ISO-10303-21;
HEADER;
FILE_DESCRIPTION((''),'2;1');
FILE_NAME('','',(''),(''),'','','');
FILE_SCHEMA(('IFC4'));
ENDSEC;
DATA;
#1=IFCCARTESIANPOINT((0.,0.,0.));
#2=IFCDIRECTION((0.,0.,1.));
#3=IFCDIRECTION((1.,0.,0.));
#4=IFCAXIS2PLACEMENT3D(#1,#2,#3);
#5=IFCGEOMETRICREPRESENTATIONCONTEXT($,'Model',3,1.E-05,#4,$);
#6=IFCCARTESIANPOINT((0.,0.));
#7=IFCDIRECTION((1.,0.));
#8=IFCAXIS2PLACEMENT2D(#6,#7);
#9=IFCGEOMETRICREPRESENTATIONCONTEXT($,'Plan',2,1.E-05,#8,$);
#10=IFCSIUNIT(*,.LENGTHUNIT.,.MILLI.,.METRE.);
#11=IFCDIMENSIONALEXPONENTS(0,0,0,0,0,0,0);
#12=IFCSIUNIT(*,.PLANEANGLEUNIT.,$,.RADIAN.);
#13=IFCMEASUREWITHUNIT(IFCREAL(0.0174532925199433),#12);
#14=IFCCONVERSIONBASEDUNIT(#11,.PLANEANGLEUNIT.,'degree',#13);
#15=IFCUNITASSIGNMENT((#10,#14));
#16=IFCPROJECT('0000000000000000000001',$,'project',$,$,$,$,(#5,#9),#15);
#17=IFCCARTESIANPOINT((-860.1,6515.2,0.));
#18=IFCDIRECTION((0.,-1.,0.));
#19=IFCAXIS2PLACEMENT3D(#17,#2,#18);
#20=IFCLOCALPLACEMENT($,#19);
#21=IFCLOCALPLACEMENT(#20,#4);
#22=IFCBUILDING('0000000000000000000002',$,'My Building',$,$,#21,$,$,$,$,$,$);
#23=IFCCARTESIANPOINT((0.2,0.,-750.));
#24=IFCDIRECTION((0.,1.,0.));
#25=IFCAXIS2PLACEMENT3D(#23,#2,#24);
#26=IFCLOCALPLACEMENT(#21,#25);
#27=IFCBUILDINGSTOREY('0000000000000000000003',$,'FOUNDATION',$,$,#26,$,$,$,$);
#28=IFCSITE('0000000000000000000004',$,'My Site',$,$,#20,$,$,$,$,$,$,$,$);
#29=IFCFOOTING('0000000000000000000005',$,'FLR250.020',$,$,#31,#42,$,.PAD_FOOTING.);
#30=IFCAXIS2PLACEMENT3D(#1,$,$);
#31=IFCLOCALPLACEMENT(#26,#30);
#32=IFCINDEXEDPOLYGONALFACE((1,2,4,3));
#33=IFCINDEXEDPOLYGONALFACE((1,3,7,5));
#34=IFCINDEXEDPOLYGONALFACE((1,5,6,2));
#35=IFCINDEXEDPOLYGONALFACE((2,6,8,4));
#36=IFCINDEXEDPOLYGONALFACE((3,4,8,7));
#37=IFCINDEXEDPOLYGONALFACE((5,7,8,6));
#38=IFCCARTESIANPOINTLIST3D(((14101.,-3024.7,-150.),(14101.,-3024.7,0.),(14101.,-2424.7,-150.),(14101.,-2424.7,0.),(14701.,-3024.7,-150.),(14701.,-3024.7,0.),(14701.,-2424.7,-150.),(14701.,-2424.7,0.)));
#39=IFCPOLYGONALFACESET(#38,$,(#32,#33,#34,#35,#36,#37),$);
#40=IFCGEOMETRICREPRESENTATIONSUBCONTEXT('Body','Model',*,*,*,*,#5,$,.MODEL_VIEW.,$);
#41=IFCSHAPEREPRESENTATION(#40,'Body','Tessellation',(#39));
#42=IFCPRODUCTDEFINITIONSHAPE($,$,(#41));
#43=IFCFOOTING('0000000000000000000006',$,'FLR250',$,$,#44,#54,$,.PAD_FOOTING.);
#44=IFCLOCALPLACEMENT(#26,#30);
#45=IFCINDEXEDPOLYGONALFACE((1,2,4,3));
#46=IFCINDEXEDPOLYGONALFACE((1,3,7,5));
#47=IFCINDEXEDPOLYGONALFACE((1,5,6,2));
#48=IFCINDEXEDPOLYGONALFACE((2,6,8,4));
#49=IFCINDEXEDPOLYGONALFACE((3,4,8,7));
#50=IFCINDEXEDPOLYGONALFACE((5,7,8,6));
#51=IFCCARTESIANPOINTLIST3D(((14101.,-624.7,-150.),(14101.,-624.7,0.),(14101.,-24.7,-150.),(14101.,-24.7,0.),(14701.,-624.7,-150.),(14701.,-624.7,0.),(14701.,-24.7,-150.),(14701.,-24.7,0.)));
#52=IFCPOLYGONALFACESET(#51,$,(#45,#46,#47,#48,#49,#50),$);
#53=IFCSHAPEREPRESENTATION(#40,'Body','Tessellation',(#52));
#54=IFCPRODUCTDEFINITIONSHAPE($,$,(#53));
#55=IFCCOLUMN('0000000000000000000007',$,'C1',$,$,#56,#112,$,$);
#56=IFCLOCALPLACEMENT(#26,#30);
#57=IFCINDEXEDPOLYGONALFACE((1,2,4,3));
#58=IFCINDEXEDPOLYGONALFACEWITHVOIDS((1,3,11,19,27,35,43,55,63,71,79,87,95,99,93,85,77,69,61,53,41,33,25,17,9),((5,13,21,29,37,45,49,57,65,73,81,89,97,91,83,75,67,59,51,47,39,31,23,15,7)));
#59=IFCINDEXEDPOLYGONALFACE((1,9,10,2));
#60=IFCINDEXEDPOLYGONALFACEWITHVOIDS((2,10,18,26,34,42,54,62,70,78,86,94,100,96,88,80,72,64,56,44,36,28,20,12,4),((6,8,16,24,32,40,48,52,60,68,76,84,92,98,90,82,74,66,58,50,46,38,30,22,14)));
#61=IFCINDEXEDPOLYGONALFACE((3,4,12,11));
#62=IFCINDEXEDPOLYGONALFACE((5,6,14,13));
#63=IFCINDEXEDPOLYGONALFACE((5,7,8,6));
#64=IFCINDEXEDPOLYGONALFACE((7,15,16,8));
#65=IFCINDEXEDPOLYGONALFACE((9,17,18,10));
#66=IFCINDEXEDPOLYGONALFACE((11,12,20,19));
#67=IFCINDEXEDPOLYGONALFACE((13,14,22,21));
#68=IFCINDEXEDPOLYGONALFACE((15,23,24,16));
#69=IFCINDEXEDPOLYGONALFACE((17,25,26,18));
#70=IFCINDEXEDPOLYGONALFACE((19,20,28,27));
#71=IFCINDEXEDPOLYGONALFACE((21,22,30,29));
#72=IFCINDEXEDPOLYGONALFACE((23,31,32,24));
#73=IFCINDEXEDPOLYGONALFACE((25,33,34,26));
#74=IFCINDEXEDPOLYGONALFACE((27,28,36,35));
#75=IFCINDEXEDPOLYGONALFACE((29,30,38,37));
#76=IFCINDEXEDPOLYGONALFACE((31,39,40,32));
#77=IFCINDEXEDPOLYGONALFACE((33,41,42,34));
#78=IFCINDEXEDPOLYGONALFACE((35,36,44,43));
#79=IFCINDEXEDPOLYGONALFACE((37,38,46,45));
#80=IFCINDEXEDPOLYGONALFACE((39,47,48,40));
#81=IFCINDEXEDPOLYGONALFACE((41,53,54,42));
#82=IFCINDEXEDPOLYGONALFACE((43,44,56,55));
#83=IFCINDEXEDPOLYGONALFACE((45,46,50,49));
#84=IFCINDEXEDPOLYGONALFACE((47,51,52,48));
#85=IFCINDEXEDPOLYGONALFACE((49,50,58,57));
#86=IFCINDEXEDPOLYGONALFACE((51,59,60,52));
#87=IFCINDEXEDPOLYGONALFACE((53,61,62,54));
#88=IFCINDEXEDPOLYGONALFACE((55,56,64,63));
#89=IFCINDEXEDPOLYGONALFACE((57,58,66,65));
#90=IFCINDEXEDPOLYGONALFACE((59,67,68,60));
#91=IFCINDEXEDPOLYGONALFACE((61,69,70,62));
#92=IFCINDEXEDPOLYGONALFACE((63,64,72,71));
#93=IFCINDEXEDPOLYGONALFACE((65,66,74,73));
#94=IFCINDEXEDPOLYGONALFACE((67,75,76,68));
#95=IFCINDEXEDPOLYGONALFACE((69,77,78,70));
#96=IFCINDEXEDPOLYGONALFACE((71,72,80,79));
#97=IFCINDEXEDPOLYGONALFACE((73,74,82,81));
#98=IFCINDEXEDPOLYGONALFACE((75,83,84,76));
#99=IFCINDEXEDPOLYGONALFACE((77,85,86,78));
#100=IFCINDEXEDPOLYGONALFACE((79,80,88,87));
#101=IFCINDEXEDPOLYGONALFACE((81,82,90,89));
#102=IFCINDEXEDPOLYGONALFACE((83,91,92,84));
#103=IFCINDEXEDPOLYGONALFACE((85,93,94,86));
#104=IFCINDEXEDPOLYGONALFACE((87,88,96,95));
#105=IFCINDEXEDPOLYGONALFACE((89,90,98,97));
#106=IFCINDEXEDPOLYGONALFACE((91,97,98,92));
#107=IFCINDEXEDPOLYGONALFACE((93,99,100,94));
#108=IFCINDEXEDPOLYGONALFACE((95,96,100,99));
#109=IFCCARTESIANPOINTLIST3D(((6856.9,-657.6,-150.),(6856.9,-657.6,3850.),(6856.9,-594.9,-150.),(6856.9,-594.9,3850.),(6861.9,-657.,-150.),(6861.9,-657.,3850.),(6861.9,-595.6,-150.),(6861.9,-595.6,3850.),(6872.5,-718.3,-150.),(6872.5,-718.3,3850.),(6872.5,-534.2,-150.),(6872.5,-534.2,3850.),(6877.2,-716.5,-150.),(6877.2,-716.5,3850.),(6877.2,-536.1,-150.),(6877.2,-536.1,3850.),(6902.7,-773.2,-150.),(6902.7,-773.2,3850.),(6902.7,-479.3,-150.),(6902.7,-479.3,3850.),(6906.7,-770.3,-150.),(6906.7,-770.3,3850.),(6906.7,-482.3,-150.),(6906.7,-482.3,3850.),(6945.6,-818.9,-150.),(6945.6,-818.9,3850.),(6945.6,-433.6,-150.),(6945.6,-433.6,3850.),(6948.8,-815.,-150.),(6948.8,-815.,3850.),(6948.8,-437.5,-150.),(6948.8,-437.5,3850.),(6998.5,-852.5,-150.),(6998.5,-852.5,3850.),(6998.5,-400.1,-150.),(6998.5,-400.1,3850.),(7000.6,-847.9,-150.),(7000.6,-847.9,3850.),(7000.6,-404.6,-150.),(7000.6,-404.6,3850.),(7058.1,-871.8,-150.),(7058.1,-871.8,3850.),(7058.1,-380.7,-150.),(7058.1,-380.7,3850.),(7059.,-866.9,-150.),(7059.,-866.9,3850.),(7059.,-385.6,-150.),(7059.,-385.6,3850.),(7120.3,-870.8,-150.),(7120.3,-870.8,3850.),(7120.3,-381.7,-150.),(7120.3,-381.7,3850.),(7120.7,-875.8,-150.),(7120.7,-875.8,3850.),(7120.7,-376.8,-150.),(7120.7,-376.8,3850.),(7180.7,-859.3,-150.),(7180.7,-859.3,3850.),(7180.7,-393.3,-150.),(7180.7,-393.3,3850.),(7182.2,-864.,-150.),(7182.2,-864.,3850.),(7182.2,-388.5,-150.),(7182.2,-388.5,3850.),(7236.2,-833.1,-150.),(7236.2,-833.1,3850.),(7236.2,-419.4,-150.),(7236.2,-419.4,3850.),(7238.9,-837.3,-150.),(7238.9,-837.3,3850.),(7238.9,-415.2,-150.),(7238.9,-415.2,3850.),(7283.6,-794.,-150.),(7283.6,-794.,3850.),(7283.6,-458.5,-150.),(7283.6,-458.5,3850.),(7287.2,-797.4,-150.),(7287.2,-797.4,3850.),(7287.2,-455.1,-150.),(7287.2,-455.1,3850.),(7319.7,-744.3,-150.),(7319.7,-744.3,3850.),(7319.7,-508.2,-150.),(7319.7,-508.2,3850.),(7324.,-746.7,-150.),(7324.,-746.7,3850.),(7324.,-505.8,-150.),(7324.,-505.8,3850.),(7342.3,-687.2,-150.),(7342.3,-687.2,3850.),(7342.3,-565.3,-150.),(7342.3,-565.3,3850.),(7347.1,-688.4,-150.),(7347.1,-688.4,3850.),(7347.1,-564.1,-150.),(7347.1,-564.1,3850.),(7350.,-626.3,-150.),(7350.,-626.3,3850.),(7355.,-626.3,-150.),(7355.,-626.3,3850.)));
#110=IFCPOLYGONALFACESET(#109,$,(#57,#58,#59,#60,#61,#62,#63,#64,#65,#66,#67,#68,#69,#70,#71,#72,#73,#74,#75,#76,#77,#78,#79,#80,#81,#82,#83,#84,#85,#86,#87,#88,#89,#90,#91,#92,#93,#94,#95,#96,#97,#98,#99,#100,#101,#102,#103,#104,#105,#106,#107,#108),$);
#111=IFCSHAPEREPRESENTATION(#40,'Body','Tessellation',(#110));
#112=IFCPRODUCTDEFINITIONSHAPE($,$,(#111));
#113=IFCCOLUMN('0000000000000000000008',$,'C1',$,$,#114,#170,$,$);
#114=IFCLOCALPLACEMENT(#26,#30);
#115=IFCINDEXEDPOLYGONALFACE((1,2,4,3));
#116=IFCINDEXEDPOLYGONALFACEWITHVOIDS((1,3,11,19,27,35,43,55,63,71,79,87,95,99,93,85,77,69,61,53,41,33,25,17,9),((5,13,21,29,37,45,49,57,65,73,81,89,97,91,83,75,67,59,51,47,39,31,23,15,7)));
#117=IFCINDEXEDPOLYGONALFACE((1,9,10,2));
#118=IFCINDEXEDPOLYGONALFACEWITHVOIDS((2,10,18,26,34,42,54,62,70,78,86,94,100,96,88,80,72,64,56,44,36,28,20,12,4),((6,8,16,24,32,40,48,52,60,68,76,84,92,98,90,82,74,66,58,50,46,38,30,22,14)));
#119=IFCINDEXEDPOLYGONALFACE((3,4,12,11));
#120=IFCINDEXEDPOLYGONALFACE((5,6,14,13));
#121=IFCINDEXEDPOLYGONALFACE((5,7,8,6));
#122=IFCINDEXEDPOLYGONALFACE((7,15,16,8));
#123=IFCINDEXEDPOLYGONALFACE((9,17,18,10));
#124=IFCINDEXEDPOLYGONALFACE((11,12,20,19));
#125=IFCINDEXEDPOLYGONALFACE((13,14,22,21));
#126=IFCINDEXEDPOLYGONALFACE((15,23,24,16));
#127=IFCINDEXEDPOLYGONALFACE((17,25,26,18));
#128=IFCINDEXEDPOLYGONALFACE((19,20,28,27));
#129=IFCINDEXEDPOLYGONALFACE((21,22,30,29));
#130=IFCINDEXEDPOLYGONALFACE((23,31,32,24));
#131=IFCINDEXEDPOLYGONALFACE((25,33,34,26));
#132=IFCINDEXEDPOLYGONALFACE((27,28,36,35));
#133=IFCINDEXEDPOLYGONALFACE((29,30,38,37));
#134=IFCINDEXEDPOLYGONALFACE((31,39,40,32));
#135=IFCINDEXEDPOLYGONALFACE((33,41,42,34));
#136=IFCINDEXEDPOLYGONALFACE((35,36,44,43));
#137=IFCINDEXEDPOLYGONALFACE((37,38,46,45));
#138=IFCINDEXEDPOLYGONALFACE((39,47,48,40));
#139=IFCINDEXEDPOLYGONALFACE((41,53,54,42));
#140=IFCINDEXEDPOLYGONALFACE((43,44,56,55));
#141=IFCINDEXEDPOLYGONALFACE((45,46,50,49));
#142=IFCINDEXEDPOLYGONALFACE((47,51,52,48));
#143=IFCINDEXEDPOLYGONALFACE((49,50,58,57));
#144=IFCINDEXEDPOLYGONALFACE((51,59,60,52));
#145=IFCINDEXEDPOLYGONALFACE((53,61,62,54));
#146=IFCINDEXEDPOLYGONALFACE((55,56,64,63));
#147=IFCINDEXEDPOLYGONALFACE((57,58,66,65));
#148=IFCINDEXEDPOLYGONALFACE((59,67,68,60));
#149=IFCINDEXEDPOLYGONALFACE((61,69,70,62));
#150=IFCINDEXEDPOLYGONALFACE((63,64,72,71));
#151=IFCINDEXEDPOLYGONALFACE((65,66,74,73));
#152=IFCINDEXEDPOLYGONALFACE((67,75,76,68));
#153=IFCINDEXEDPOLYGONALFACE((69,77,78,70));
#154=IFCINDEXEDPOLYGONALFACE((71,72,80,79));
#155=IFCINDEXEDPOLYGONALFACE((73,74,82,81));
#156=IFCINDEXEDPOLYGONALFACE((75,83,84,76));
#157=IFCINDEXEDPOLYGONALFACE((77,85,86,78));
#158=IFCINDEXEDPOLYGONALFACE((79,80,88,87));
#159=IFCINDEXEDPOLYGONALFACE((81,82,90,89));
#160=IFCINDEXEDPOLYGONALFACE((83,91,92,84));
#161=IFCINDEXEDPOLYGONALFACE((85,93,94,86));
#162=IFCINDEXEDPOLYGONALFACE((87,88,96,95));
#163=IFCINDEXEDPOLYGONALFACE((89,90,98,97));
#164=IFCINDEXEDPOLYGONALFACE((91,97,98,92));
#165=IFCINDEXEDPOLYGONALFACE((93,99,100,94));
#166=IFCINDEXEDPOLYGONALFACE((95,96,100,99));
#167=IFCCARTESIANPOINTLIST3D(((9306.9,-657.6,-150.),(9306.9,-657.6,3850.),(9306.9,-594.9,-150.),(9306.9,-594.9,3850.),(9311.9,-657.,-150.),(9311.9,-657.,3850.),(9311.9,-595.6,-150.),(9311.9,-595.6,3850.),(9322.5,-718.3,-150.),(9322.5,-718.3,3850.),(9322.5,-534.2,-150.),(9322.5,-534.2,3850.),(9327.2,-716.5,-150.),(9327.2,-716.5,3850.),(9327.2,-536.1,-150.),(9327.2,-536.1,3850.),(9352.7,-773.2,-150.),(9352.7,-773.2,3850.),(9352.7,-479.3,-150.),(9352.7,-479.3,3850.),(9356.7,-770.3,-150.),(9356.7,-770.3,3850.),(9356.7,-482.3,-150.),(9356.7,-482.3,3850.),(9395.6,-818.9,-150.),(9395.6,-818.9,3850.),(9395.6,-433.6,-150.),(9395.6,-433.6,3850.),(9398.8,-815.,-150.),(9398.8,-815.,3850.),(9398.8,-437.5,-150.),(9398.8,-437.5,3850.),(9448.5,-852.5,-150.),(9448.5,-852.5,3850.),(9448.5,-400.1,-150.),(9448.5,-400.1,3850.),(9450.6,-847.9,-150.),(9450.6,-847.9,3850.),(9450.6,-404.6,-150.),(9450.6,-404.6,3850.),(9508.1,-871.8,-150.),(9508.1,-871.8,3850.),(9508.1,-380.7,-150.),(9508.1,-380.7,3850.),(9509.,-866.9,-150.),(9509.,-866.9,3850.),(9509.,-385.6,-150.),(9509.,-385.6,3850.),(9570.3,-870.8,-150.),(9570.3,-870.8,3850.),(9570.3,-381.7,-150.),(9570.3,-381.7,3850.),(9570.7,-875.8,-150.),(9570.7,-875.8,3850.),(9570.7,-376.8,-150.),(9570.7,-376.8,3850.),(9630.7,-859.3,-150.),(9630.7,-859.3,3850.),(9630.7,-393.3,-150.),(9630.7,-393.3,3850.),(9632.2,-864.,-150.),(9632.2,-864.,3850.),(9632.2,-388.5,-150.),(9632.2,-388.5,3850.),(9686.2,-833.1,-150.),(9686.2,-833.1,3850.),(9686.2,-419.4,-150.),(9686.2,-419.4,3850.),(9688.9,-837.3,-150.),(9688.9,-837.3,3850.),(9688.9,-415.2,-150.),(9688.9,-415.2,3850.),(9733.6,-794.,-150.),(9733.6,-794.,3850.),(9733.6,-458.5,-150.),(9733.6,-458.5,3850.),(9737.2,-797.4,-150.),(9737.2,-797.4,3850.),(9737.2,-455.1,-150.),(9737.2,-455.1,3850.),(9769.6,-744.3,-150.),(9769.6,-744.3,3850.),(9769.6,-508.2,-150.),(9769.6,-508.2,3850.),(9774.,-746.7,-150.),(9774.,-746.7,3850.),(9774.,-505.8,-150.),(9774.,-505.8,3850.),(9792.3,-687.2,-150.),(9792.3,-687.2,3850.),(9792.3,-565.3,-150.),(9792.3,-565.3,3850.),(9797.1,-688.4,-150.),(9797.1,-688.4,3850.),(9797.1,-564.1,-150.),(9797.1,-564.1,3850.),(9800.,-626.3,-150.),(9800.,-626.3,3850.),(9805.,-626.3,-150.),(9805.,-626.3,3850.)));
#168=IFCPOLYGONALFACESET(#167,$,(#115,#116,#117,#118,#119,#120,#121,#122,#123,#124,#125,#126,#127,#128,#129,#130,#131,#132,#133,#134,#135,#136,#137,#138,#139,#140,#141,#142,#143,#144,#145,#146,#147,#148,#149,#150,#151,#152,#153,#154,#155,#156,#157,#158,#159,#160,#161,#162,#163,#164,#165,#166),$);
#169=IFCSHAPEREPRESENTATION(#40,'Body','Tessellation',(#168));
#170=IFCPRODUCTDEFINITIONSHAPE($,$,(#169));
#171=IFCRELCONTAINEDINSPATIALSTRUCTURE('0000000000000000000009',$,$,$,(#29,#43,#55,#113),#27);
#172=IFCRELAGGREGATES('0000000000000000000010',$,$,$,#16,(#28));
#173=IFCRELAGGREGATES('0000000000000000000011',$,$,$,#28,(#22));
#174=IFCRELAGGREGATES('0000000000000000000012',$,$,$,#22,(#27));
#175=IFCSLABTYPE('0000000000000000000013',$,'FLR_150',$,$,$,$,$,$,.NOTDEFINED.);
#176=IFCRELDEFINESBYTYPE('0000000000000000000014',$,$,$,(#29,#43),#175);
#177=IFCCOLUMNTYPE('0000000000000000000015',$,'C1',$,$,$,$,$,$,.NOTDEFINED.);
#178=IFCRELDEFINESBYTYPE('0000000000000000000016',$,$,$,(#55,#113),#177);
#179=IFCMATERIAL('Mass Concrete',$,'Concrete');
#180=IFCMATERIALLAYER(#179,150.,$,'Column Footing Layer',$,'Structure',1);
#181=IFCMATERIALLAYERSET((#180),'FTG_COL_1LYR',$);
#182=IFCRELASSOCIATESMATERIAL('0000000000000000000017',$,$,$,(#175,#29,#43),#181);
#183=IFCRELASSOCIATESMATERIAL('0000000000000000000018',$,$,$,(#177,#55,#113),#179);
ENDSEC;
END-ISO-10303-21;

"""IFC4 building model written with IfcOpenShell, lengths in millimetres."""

from ifc_helpers import new_model, entity, si_unit, converted_unit, frame, origin_with_axes, origin_2d_with_axis, place, context, subcontext, project, spatial, line, indexed_curve, rectangle, hollow_circle, outline, extrude, material, layer, layer_set, layer_usage, material_profile, profile_set, profile_usage, type_object, element, save


model = new_model("IFC4")

# Units and contexts
model_context = context("Model", 3, precision=1e-05, world=origin_with_axes())
plan_context = context("Plan", 2, precision=1e-05, world=origin_2d_with_axis())
body_context = subcontext(model_context, "Body", "Model", "MODEL_VIEW")
ifc_project = project(units=[si_unit("LENGTHUNIT", "METRE", prefix="MILLI"), converted_unit("PLANEANGLEUNIT", "degree", entity("IfcReal", 0.0174532925199433), si_unit("PLANEANGLEUNIT", "RADIAN"), dimensions=[0, 0, 0, 0, 0, 0, 0])], contexts=[model_context, plan_context])

# Site, building, storey
site_placement = place(None, frame((-860.1, 6515.2, 0.0), z_axis=(0.0, 0.0, 1.0), x_axis=(0.0, -1.0, 0.0)))
site = spatial("IfcSite", under=ifc_project, at=site_placement, Name="My Site")
building_placement = place(site_placement, frame((0.0, 0.0, 0.0), z_axis=(0.0, 0.0, 1.0), x_axis=(1.0, 0.0, 0.0)))
building = spatial("IfcBuilding", under=site, at=building_placement, Name="My Building")
storey_placement = place(building_placement, frame((0.2, 0.0, -750.0), z_axis=(0.0, 0.0, 1.0), x_axis=(0.0, 1.0, 0.0)))
storey = spatial("IfcBuildingStorey", under=building, at=storey_placement, Name="FOUNDATION")

# Footings
ifc_material_1 = material(Name="Mass Concrete", Category="Concrete")
ifc_layer_1 = layer(ifc_material_1, 150.0, Name="Column Footing Layer", Category="Structure", Priority=1)
ifc_layer_set_1 = layer_set([ifc_layer_1], Name="FTG_COL_1LYR")
slab_type = type_object("IfcSlabType", Name="FLR_150", PredefinedType="NOTDEFINED", material=ifc_layer_set_1)
ifc_layer_usage_1 = layer_usage(ifc_layer_set_1, "AXIS3", "POSITIVE", 0.0)
footing_1_placement = place(storey_placement, frame((14101.0, -3024.7, -150.0), z_axis=(0.0, 0.0, 1.0), x_axis=(1.0, 0.0, 0.0)))
element("IfcFooting", 1, at=footing_1_placement, inside=storey, type_object=slab_type, material=ifc_layer_usage_1, Name="FLR250.020", PredefinedType="PAD_FOOTING", context=body_context, shape_type="SweptSolid", body=[
    extrude(outline(indexed_curve([(0.0, 0.0), (600.0, 0.0), (600.0, 600.0), (0.0, 600.0)], segments=[line(3, 2), line(2, 1), line(1, 4), line(4, 3)], self_intersect=False)), None, (0.0, 0.0, 1.0), 150.0),
])
ifc_layer_usage_2 = layer_usage(ifc_layer_set_1, "AXIS3", "POSITIVE", 0.0)
footing_2_placement = place(storey_placement, frame((14101.0, -624.7, -150.0), z_axis=(0.0, 0.0, 1.0), x_axis=(1.0, 0.0, 0.0)))
element("IfcFooting", 2, at=footing_2_placement, inside=storey, type_object=slab_type, material=ifc_layer_usage_2, Name="FLR250", PredefinedType="PAD_FOOTING", context=body_context, shape_type="SweptSolid", body=[
    extrude(outline(indexed_curve([(0.0, 0.0), (600.0, 0.0), (600.0, 600.0), (0.0, 600.0)], segments=[line(3, 2), line(2, 1), line(1, 4), line(4, 3)], self_intersect=False)), None, (0.0, 0.0, 1.0), 150.0),
])

# Columns
ifc_material_profile = material_profile(ifc_material_1, rectangle(XDim=150.0, YDim=150.0), Name="Square Column", Category="Structure", Priority=1)
ifc_profile_set = profile_set([ifc_material_profile], Name="RC_COL_150x150")
ifc_profile_usage_1 = profile_usage(ifc_profile_set, cardinal=5)
column_type = type_object("IfcColumnType", Name="C1", PredefinedType="NOTDEFINED", material=ifc_profile_set)
column_1_placement = place(storey_placement, frame((7105.0, -626.3, -150.0), z_axis=(0.0, 0.0, 1.0), x_axis=(1.0, 0.0, 0.0)))
element("IfcColumn", 3, at=column_1_placement, inside=storey, type_object=column_type, material=ifc_profile_usage_1, Name="C1", context=body_context, shape_type="SweptSolid", body=[
    extrude(hollow_circle(Radius=250.0, WallThickness=5.0), origin_with_axes(), (0.0, 0.0, 1.0), 4000.0),
])
ifc_profile_usage_2 = profile_usage(ifc_profile_set, cardinal=5)
column_2_placement = place(storey_placement, frame((9555.0, -626.3, -150.0), z_axis=(0.0, 0.0, 1.0), x_axis=(1.0, 0.0, 0.0)))
element("IfcColumn", 4, at=column_2_placement, inside=storey, type_object=column_type, material=ifc_profile_usage_2, Name="C1", context=body_context, shape_type="SweptSolid", body=[
    extrude(hollow_circle(Radius=250.0, WallThickness=5.0), origin_with_axes(), (0.0, 0.0, 1.0), 4000.0),
])

save(model, "model.ifc")
